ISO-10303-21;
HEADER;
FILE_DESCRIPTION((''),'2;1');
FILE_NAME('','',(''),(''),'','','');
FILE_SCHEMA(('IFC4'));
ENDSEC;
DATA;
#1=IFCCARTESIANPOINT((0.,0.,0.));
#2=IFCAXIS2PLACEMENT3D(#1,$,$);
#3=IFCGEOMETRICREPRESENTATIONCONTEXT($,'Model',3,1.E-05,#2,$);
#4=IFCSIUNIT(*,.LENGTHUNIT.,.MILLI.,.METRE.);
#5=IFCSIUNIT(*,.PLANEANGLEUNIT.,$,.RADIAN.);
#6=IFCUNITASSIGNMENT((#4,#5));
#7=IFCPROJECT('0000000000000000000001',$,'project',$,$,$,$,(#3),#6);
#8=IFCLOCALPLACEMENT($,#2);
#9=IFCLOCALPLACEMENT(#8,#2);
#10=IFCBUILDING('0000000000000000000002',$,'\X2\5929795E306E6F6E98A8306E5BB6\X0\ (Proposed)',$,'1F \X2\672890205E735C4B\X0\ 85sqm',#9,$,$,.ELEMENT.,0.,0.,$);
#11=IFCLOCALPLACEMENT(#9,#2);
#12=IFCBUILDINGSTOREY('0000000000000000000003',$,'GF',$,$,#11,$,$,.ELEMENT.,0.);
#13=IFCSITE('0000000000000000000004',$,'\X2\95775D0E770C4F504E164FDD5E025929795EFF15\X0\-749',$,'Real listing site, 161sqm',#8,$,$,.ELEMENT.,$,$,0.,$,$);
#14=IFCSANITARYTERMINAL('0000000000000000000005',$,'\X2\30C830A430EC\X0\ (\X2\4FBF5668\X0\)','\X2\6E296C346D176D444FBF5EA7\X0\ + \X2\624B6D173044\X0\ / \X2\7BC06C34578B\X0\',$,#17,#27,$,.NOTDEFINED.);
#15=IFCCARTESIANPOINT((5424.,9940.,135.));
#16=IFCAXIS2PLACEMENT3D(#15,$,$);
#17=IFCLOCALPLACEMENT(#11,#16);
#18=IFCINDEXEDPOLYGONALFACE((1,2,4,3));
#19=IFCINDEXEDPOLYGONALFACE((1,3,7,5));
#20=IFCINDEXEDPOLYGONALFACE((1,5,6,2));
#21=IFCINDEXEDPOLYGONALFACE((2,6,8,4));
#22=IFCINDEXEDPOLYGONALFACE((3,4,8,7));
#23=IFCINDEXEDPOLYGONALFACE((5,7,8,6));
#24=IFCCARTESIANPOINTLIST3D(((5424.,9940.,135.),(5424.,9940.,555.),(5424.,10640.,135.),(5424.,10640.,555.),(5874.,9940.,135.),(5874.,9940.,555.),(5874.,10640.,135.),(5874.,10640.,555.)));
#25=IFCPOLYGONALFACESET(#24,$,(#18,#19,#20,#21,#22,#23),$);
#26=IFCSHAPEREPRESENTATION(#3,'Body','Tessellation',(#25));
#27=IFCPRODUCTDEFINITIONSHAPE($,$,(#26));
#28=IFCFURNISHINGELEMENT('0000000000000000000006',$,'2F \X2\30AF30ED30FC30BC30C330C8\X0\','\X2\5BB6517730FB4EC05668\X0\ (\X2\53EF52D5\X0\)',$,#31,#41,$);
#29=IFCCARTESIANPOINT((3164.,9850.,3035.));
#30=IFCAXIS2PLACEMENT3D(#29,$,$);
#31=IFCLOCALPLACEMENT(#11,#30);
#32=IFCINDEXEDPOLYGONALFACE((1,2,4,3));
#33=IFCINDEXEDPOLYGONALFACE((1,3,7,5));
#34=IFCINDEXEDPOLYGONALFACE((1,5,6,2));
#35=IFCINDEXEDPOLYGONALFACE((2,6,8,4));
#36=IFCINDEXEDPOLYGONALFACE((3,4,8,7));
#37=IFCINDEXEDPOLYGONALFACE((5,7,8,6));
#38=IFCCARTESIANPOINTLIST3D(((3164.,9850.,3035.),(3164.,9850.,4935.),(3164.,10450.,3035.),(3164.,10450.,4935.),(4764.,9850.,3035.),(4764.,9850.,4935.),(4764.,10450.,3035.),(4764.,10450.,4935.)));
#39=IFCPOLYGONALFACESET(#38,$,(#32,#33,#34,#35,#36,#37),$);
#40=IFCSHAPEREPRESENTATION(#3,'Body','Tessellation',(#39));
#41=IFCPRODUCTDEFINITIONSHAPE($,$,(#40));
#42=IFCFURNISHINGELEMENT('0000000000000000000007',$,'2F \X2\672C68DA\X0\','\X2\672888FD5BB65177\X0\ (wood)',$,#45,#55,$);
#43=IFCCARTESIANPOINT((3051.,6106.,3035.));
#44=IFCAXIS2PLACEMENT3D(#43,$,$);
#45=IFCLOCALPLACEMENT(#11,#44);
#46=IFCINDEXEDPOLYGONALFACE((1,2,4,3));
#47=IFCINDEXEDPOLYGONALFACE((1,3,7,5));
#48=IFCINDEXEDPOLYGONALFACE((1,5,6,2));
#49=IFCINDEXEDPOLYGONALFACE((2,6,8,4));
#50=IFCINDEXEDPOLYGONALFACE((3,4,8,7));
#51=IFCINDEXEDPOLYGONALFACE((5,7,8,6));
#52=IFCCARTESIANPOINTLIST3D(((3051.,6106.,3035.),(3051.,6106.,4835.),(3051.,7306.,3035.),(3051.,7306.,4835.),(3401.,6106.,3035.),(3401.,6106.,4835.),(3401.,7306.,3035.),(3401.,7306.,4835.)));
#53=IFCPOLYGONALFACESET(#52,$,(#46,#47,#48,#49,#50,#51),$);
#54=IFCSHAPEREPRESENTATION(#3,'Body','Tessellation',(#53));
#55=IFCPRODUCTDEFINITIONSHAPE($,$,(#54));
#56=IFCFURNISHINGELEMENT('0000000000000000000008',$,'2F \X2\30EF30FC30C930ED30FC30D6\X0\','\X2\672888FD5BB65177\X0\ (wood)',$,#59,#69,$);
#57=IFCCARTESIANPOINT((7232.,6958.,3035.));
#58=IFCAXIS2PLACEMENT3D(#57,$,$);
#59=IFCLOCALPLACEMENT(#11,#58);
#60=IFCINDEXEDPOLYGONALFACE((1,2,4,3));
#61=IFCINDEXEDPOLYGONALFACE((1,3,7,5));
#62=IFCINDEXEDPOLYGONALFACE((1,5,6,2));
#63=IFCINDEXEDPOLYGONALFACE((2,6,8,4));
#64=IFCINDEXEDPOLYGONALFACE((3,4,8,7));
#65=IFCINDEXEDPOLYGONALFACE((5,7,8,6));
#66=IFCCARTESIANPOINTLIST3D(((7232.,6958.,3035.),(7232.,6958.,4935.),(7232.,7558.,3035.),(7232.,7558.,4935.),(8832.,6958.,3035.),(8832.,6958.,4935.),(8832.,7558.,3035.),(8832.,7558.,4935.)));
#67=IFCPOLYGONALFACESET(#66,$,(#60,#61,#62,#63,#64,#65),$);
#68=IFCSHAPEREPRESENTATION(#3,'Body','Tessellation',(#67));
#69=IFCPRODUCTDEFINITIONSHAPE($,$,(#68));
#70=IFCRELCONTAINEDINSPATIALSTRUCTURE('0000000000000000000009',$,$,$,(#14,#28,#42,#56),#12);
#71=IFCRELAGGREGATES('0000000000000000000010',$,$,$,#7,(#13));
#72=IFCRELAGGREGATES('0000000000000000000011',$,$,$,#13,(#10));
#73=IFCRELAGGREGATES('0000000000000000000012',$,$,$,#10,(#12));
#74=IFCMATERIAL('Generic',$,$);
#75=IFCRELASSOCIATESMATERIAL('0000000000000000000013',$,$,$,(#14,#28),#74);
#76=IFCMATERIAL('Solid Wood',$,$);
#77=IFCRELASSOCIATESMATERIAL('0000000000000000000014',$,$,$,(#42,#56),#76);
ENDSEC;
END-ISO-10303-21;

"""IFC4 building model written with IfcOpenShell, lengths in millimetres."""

from ifc_helpers import new_model, si_unit, frame, frame_2d, origin, place, context, project, spatial, rectangle, extrude, material, element, save


model = new_model("IFC4")

# Units and contexts
model_context = context("Model", 3, precision=1e-05, world=origin())
ifc_project = project(units=[si_unit("LENGTHUNIT", "METRE", prefix="MILLI"), si_unit("PLANEANGLEUNIT", "RADIAN")], contexts=[model_context])

# Site, building, storey
site_placement = place(None, origin())
site = spatial("IfcSite", under=ifc_project, at=site_placement, Name="長崎県佐世保市天神５-749", ObjectType="Real listing site, 161sqm", CompositionType="ELEMENT", RefElevation=0.0)
building_placement = place(site_placement, origin())
building = spatial("IfcBuilding", under=site, at=building_placement, Name="天神の潮風の家 (Proposed)", ObjectType="1F 木造平屋 85sqm", CompositionType="ELEMENT", ElevationOfRefHeight=0.0, ElevationOfTerrain=0.0)
storey_placement = place(building_placement, origin())
storey = spatial("IfcBuildingStorey", under=building, at=storey_placement, Name="GF", CompositionType="ELEMENT", Elevation=0.0)

# Shared definitions
ifc_material_1 = material(Name="Solid Wood")

# Shared definitions
ifc_material_2 = material(Name="Generic")

# Sanitary terminal
sanitary_terminal_placement = place(storey_placement, frame((5424.0, 9940.0, 135.0)))
element("IfcSanitaryTerminal", 1, at=sanitary_terminal_placement, inside=storey, material=ifc_material_2, Name="トイレ (便器)", Description="温水洗浄便座 + 手洗い / 節水型", PredefinedType="NOTDEFINED", context=model_context, shape_type="SweptSolid", body=[
    extrude(rectangle(XDim=450.0, YDim=700.0, at=frame_2d((225.0, 350.0))), frame((5424.0, 9940.0, 135.0)), (0.0, 0.0, 1.0), 420.0),
])

# Furnishing elements
furnishing_1_placement = place(storey_placement, frame((3164.0, 9850.0, 3035.0)))
element("IfcFurnishingElement", 2, at=furnishing_1_placement, inside=storey, material=ifc_material_2, Name="2F クローゼット", Description="家具・什器 (可動)", context=model_context, shape_type="SweptSolid", body=[
    extrude(rectangle(XDim=1600.0, YDim=600.0, at=frame_2d((800.0, 300.0))), frame((3164.0, 9850.0, 3035.0)), (0.0, 0.0, 1.0), 1900.0),
])
furnishing_2_placement = place(storey_placement, frame((3051.0, 6106.0, 3035.0)))
element("IfcFurnishingElement", 3, at=furnishing_2_placement, inside=storey, material=ifc_material_1, Name="2F 本棚", Description="木製家具 (wood)", context=model_context, shape_type="SweptSolid", body=[
    extrude(rectangle(XDim=350.0, YDim=1200.0, at=frame_2d((175.0, 600.0))), frame((3051.0, 6106.0, 3035.0)), (0.0, 0.0, 1.0), 1800.0),
])
furnishing_3_placement = place(storey_placement, frame((7232.0, 6958.0, 3035.0)))
element("IfcFurnishingElement", 4, at=furnishing_3_placement, inside=storey, material=ifc_material_1, Name="2F ワードローブ", Description="木製家具 (wood)", context=model_context, shape_type="SweptSolid", body=[
    extrude(rectangle(XDim=1600.0, YDim=600.0, at=frame_2d((800.0, 300.0))), frame((7232.0, 6958.0, 3035.0)), (0.0, 0.0, 1.0), 1900.0),
])

save(model, "model.ifc")
